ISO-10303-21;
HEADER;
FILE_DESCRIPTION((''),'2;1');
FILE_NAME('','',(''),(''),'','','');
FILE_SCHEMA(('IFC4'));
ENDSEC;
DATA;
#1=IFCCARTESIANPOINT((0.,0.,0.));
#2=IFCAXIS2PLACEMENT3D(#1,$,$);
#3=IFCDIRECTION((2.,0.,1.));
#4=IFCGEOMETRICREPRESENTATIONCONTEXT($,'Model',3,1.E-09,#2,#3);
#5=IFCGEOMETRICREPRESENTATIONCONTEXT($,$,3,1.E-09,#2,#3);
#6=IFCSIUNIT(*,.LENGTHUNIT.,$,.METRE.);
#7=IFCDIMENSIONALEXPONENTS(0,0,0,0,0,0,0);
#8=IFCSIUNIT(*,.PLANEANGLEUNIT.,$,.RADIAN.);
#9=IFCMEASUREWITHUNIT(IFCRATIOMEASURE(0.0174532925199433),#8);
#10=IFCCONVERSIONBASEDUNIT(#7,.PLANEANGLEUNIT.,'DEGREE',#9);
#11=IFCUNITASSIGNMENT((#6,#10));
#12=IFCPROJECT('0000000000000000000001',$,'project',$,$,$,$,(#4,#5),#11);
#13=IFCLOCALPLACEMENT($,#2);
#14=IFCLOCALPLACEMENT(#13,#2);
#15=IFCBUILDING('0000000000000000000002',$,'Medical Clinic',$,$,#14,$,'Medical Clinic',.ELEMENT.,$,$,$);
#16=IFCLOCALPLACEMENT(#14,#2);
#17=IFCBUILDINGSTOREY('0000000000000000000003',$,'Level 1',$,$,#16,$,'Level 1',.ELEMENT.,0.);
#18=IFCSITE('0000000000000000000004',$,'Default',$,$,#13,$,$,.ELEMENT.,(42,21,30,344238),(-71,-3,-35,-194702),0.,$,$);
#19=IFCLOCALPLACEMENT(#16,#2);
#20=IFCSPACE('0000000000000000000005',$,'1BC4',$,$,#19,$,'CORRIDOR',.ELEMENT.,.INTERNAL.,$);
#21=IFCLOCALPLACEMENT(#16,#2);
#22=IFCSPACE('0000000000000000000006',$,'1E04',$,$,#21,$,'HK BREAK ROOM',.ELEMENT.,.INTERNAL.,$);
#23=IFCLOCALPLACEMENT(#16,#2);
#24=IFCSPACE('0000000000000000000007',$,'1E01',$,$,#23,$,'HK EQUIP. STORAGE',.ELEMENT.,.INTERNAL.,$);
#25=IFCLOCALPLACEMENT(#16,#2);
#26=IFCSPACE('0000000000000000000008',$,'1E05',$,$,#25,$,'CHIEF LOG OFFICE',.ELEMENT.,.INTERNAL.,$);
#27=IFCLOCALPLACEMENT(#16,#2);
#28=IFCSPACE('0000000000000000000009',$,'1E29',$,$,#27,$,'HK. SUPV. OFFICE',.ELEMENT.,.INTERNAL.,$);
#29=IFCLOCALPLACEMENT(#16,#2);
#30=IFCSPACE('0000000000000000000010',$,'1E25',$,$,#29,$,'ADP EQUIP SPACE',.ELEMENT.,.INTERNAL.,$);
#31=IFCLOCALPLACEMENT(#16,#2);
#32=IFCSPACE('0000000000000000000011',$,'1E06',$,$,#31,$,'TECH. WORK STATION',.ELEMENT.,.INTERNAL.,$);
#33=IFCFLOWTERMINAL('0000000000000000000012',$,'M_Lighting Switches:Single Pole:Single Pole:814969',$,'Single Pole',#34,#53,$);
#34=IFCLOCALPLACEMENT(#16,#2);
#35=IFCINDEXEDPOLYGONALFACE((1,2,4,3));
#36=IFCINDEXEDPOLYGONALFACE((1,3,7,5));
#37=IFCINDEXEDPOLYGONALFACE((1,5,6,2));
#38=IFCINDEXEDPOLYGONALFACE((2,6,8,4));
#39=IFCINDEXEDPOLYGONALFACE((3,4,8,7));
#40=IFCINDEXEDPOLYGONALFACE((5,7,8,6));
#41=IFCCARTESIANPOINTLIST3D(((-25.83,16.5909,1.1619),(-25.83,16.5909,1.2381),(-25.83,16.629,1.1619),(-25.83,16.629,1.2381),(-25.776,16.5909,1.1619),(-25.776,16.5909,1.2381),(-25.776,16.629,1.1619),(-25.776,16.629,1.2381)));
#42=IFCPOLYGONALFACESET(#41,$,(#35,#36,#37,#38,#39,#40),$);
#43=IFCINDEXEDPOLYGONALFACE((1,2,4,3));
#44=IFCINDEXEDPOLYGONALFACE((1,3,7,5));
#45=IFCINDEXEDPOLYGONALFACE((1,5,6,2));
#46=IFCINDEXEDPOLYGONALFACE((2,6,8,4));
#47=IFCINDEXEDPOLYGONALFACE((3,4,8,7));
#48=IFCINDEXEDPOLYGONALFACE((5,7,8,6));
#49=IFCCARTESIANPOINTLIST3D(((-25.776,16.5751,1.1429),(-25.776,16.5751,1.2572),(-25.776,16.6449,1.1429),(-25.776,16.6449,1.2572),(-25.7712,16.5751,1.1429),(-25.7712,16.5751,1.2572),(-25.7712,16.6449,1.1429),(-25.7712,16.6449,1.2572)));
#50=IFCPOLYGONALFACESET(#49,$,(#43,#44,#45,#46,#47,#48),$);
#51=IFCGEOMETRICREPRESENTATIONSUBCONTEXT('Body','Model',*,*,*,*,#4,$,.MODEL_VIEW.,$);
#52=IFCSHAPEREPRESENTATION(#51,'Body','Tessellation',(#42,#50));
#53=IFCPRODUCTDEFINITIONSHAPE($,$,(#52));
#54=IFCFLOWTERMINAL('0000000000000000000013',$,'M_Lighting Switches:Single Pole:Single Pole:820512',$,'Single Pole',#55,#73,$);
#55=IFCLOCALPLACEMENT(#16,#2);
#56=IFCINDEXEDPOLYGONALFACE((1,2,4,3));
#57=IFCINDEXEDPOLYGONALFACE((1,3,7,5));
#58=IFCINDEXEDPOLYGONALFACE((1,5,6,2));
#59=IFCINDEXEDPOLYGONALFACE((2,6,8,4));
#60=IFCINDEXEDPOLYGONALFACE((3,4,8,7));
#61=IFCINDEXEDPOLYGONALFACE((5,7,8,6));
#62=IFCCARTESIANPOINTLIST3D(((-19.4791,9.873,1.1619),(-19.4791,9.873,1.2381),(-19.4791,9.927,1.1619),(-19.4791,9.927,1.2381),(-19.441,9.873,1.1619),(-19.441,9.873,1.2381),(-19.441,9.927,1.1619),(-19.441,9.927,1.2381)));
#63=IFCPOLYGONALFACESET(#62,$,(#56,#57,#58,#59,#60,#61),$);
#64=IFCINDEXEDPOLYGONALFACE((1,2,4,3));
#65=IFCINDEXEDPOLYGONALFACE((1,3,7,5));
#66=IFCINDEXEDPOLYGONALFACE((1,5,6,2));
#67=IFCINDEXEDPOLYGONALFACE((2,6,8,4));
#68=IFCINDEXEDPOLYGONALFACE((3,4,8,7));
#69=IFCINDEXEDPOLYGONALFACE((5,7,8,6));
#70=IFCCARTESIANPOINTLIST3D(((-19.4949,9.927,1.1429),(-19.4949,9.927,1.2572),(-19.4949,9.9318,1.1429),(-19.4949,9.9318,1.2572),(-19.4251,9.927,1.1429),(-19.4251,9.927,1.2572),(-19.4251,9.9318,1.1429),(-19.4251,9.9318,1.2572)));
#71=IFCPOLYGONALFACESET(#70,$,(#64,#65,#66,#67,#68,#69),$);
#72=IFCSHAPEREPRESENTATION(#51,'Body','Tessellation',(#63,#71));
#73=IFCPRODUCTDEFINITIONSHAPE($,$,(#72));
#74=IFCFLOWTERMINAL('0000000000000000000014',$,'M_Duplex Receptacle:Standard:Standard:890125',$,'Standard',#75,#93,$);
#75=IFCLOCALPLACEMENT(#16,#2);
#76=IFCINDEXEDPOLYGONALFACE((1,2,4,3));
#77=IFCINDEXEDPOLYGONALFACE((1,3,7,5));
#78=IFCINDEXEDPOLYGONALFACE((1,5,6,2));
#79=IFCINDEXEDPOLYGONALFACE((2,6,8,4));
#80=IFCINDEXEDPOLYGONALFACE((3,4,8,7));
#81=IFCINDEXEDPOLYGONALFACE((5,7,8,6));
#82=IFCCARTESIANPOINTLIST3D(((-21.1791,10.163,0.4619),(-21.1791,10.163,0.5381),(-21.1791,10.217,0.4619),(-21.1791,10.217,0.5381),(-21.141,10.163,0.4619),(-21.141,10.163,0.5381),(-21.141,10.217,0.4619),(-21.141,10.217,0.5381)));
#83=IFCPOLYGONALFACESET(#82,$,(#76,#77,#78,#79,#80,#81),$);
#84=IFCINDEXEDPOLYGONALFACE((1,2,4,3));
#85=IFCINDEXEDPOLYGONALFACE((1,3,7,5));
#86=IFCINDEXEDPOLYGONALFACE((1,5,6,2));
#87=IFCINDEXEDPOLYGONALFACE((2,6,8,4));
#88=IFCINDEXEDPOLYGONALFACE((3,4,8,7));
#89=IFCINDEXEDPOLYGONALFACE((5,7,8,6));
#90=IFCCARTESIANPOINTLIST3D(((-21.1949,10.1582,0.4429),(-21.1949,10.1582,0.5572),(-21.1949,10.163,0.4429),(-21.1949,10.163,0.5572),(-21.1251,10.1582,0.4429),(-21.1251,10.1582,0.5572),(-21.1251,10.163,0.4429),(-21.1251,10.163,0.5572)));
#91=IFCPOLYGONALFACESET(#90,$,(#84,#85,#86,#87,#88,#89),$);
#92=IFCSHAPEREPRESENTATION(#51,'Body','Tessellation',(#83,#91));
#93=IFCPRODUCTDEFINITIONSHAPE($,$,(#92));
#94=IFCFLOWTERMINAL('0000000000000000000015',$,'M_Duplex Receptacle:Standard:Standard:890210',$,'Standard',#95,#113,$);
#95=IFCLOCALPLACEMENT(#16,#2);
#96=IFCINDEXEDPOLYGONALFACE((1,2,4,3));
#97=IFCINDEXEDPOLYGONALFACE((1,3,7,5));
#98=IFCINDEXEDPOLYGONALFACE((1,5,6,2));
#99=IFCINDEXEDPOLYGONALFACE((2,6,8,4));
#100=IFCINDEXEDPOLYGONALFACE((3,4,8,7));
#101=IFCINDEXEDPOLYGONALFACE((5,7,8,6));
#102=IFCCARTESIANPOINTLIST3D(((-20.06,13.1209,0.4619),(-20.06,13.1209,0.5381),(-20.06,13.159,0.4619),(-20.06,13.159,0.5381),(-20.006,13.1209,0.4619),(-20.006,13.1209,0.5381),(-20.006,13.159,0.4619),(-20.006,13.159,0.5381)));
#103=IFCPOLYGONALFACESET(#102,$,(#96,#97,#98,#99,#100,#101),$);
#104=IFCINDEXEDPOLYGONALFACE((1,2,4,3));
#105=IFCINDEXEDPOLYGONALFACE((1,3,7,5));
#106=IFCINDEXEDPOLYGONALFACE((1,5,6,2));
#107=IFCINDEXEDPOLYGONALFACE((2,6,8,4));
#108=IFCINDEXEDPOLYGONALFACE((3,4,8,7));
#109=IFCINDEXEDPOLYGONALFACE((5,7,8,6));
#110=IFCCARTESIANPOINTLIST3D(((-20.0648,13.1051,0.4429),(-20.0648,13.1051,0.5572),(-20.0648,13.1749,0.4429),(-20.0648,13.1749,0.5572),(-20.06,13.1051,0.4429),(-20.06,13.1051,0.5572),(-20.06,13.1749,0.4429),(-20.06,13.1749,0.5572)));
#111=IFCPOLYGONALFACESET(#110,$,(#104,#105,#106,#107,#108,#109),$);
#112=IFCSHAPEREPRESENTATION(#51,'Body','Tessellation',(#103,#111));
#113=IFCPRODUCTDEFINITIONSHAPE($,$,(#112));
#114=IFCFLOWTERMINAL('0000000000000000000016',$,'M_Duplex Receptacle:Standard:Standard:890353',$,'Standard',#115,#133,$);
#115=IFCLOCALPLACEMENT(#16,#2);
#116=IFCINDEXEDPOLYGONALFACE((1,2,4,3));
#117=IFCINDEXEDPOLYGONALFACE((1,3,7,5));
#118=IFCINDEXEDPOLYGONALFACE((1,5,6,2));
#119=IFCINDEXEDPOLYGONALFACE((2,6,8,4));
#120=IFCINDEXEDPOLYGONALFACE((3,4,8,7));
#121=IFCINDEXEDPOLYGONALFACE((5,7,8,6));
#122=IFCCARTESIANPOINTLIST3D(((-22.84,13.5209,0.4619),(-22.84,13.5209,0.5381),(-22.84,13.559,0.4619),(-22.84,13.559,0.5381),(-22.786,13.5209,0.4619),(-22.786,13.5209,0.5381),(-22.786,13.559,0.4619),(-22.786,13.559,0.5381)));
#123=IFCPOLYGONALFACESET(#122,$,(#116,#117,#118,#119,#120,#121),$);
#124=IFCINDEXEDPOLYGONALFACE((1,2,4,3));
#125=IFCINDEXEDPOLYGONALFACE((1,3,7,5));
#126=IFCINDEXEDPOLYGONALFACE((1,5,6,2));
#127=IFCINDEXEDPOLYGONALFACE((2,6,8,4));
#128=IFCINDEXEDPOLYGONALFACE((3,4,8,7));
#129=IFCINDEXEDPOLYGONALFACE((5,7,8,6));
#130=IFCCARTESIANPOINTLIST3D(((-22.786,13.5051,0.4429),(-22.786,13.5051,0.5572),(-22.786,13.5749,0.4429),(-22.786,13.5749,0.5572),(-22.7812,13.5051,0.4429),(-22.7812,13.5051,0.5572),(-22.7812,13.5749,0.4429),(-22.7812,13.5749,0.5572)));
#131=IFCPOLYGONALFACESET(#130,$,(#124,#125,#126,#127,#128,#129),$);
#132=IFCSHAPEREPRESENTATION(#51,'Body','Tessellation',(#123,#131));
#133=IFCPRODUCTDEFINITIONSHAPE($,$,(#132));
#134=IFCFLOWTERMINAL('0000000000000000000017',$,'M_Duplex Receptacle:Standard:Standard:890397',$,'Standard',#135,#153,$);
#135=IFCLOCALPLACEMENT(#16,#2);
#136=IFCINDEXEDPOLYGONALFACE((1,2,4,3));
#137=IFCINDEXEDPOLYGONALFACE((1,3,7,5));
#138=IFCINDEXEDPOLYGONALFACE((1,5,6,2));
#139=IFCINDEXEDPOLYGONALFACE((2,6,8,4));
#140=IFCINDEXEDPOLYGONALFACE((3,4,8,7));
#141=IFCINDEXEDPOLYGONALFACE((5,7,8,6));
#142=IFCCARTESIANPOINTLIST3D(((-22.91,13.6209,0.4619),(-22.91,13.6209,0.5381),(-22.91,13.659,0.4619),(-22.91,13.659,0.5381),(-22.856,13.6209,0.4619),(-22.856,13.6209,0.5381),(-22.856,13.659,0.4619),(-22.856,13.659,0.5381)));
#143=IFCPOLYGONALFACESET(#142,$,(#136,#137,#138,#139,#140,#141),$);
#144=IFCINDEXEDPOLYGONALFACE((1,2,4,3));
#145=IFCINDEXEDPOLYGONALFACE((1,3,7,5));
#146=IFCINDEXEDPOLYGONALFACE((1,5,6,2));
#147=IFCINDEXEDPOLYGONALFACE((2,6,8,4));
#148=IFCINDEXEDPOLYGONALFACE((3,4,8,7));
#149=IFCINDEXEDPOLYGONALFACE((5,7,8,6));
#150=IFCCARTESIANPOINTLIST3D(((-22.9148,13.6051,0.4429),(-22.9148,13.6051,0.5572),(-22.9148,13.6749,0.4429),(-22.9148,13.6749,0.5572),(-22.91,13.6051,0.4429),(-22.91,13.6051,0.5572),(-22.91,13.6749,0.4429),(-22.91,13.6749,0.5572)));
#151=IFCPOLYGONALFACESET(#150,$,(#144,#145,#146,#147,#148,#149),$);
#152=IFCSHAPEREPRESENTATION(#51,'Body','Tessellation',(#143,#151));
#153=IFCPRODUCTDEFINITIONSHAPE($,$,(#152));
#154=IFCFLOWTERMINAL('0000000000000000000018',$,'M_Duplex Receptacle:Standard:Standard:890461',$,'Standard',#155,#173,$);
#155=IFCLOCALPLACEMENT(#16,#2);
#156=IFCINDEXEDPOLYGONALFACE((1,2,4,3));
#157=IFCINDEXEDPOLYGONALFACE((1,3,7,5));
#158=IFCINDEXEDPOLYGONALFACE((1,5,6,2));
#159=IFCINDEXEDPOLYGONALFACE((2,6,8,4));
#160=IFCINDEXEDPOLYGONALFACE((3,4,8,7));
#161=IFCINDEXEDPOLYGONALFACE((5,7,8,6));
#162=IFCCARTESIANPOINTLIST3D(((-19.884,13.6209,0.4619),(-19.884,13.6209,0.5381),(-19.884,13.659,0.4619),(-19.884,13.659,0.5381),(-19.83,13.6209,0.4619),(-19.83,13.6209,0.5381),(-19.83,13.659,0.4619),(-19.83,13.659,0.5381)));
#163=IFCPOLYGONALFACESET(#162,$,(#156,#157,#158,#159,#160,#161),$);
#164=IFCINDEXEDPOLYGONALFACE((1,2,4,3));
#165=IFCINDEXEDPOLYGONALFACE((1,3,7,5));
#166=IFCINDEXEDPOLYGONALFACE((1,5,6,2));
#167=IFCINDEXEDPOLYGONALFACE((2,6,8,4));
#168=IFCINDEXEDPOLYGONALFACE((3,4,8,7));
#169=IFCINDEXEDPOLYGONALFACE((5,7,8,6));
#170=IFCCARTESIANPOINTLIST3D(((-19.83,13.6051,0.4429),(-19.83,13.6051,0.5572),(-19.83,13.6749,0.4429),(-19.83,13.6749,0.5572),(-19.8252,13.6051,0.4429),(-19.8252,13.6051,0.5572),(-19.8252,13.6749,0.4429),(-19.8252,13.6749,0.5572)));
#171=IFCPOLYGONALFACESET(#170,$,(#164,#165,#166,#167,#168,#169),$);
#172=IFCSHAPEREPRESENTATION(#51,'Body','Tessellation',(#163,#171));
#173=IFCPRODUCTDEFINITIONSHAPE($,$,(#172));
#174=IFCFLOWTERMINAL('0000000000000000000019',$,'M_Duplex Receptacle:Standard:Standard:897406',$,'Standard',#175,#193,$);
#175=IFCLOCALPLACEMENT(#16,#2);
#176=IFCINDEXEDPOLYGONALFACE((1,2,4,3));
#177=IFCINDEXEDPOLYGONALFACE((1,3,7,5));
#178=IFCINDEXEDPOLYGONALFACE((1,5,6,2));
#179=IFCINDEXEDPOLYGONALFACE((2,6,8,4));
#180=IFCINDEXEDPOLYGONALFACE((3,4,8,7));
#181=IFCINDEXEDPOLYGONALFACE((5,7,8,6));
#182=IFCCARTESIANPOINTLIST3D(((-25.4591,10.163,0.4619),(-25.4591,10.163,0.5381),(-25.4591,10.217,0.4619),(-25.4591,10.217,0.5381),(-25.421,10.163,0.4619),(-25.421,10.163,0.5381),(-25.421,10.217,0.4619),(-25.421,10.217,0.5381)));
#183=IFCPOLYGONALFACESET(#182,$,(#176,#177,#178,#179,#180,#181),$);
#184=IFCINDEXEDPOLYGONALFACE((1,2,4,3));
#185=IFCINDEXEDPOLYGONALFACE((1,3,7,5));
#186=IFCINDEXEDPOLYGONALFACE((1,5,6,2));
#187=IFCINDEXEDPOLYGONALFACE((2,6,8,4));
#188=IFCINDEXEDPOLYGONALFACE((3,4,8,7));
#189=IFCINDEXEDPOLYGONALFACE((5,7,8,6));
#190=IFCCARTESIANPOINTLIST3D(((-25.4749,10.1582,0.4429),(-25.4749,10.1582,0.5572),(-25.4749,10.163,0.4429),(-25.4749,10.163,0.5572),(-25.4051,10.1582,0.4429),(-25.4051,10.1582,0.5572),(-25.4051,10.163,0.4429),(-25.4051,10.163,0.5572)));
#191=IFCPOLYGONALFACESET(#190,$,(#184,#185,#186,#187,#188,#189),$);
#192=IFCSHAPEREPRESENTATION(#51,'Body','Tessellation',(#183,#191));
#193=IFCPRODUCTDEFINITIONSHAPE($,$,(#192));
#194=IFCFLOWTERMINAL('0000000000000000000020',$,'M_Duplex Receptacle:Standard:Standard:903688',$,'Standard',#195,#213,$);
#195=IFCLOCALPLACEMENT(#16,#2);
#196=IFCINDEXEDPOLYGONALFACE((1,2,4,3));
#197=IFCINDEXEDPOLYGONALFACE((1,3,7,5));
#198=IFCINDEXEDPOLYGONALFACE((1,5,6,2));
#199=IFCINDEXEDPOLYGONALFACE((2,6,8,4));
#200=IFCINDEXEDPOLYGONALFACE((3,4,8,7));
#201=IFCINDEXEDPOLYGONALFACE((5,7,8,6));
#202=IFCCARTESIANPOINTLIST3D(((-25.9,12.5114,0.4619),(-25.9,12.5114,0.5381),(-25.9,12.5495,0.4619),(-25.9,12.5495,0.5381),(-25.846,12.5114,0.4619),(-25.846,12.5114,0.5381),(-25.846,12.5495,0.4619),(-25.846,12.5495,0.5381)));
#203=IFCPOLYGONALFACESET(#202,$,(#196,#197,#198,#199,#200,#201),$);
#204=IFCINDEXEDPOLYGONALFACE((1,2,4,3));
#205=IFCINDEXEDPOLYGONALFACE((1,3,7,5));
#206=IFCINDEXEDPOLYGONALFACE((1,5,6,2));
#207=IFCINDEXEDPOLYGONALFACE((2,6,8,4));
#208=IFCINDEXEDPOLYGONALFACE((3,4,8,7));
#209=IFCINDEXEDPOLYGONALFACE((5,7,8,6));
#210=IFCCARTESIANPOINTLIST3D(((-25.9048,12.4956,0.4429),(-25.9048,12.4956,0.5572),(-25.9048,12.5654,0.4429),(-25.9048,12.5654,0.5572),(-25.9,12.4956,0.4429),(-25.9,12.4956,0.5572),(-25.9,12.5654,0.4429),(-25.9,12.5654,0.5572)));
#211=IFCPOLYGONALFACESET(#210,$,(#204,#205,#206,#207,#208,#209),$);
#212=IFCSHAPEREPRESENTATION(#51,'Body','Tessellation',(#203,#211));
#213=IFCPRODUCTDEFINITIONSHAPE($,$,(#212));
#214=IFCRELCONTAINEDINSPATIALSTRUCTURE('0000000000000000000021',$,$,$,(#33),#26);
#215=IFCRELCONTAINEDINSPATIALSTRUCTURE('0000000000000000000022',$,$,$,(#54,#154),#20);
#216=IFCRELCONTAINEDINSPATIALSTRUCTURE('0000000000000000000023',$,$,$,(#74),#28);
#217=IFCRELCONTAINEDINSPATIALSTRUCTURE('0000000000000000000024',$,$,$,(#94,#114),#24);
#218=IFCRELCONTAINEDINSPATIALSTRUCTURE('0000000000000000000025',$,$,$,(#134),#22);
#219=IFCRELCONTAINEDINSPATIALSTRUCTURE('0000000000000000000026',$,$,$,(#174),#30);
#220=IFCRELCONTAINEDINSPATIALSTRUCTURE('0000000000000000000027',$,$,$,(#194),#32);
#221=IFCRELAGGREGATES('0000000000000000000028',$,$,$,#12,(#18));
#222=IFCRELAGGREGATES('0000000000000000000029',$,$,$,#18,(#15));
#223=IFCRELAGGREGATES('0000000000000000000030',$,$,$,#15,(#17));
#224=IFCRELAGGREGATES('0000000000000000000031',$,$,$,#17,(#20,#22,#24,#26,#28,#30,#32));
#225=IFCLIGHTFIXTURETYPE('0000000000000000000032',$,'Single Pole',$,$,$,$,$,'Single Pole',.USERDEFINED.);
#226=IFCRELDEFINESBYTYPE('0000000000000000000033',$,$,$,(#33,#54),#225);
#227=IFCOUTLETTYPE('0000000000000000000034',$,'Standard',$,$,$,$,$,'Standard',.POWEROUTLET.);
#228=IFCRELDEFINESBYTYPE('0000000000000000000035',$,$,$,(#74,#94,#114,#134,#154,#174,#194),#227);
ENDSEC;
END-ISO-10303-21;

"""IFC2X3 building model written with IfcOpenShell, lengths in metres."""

from ifc_helpers import new_model, entity, si_unit, converted_unit, direction, frame, frame_2d, origin, origin_2d_with_axis, place, context, subcontext, project, spatial, rectangle, extrude, source, transform, mapped, type_object, type_shapes, element, save


model = new_model("IFC2X3")

# Units and contexts
model_context = context("Model", 3, precision=1e-09, world=origin(), true_north=direction((2.0, 0.0, 1.0)))
context_of_model = context(None, 3, precision=1e-09, world=origin(), true_north=direction((2.0, 0.0, 1.0)))
body_context = subcontext(model_context, "Body", "Model", "MODEL_VIEW")
ifc_project = project(units=[si_unit("LENGTHUNIT", "METRE"), converted_unit("PLANEANGLEUNIT", "DEGREE", entity("IfcRatioMeasure", 0.0174532925199433), si_unit("PLANEANGLEUNIT", "RADIAN"), dimensions=[0, 0, 0, 0, 0, 0, 0])], contexts=[model_context, context_of_model])

# Site, building, storey
site_placement = place(None, origin())
site = spatial("IfcSite", under=ifc_project, at=site_placement, Name="Default", CompositionType="ELEMENT", RefLatitude=(42, 21, 30, 344238), RefLongitude=(-71, -3, -35, -194702), RefElevation=0.0)
building_placement = place(site_placement, origin())
building = spatial("IfcBuilding", under=site, at=building_placement, Name="Medical Clinic", LongName="Medical Clinic", CompositionType="ELEMENT")
storey_placement = place(building_placement, origin())
storey = spatial("IfcBuildingStorey", under=building, at=storey_placement, Name="Level 1", LongName="Level 1", CompositionType="ELEMENT", Elevation=0.0)

# Shared definitions
space_1_placement = place(storey_placement, origin())
space_1 = spatial("IfcSpace", under=storey, at=space_1_placement, Name="1BC4", LongName="CORRIDOR", CompositionType="ELEMENT", InteriorOrExteriorSpace="INTERNAL")

# Shared definitions
space_2_placement = place(storey_placement, origin())
space_2 = spatial("IfcSpace", under=storey, at=space_2_placement, Name="1E04", LongName="HK BREAK ROOM", CompositionType="ELEMENT", InteriorOrExteriorSpace="INTERNAL")

# Shared definitions
light_fixture_type_1 = type_object("IfcLightFixtureType", Name="Single Pole", ElementType="Single Pole", PredefinedType="USERDEFINED")
shared_shape_1 = source(origin(), body_context, "Body", "SweptSolid", [
    extrude(rectangle(XDim=0.0381, YDim=0.0762, at=origin_2d_with_axis()), frame((0.0, 0.0, -0.054), z_axis=(0.0, 0.0, 1.0), x_axis=(-1.0, 0.0, 0.0)), (0.0, 0.0, 1.0), 0.054),
    extrude(rectangle(XDim=0.0698, YDim=0.1143, at=frame_2d((0.0, 0.0), x_axis=(1.0, 0.0))), frame((0.0, 0.0, 0.0), z_axis=(0.0, 0.0, 1.0), x_axis=(-1.0, 0.0, 0.0)), (0.0, 0.0, 1.0), 0.0048),
])
type_shapes(light_fixture_type_1, [shared_shape_1])

# Shared definitions
space_3_placement = place(storey_placement, origin())
space_3 = spatial("IfcSpace", under=storey, at=space_3_placement, Name="1E01", LongName="HK EQUIP. STORAGE", CompositionType="ELEMENT", InteriorOrExteriorSpace="INTERNAL")

# Shared definitions
space_4_placement = place(storey_placement, origin())
space_4 = spatial("IfcSpace", under=storey, at=space_4_placement, Name="1E05", LongName="CHIEF LOG OFFICE", CompositionType="ELEMENT", InteriorOrExteriorSpace="INTERNAL")

# Flow terminals
flow_terminal_1_placement = place(space_4_placement, frame((-25.776, 16.61, 1.2), z_axis=(1.0, 0.0, 0.0), x_axis=(0.0, 1.0, 0.0)))
element("IfcFlowTerminal", 1, at=flow_terminal_1_placement, inside=space_4, type_object=light_fixture_type_1, Name="M_Lighting Switches:Single Pole:Single Pole:814969", ObjectType="Single Pole", context=body_context, shape_type="MappedRepresentation", body=[
    mapped(shared_shape_1, transform((0.0, 0.0, 0.0), scale=1.0)),
])
flow_terminal_2_placement = place(space_1_placement, frame((-19.46, 9.927, 1.2), z_axis=(0.0, 1.0, 0.0), x_axis=(-1.0, 0.0, 0.0)))
element("IfcFlowTerminal", 2, at=flow_terminal_2_placement, inside=space_1, type_object=light_fixture_type_1, Name="M_Lighting Switches:Single Pole:Single Pole:820512", ObjectType="Single Pole", context=body_context, shape_type="MappedRepresentation", body=[
    mapped(shared_shape_1, transform((0.0, 0.0, 0.0), scale=1.0)),
])

# Shared definitions
space_5_placement = place(storey_placement, origin())
space_5 = spatial("IfcSpace", under=storey, at=space_5_placement, Name="1E29", LongName="HK. SUPV. OFFICE", CompositionType="ELEMENT", InteriorOrExteriorSpace="INTERNAL")

# Flow terminals
outlet_type = type_object("IfcOutletType", Name="Standard", ElementType="Standard", PredefinedType="POWEROUTLET")
shared_shape_2 = source(origin(), body_context, "Body", "SweptSolid", [
    extrude(rectangle(XDim=0.0381, YDim=0.0762, at=origin_2d_with_axis()), frame((0.0, 0.0, -0.054), z_axis=(0.0, 0.0, 1.0), x_axis=(-1.0, 0.0, 0.0)), (0.0, 0.0, 1.0), 0.054),
    extrude(rectangle(XDim=0.0698, YDim=0.1143, at=frame_2d((0.0, 0.0), x_axis=(1.0, 0.0))), frame((0.0, 0.0, 0.0), z_axis=(0.0, 0.0, 1.0), x_axis=(-1.0, 0.0, 0.0)), (0.0, 0.0, 1.0), 0.0048),
])
type_shapes(outlet_type, [shared_shape_2])
flow_terminal_3_placement = place(space_5_placement, frame((-21.16, 10.163, 0.5), z_axis=(0.0, -1.0, 0.0), x_axis=(1.0, 0.0, 0.0)))
element("IfcFlowTerminal", 3, at=flow_terminal_3_placement, inside=space_5, type_object=outlet_type, Name="M_Duplex Receptacle:Standard:Standard:890125", ObjectType="Standard", context=body_context, shape_type="MappedRepresentation", body=[
    mapped(shared_shape_2, transform((0.0, 0.0, 0.0), scale=1.0)),
])
for number, where, z_axis, x_axis, name in (
    (4, (-20.06, 13.14, 0.5), (-1.0, 0.0, 0.0), (0.0, -1.0, 0.0), "M_Duplex Receptacle:Standard:Standard:890210"),
    (5, (-22.786, 13.54, 0.5), (1.0, 0.0, 0.0), (0.0, 1.0, 0.0), "M_Duplex Receptacle:Standard:Standard:890353"),
):
    element("IfcFlowTerminal", number, at=place(space_3_placement, frame(where, z_axis=z_axis, x_axis=x_axis)), inside=space_3, type_object=outlet_type, Name=name, ObjectType="Standard", context=body_context, shape_type="MappedRepresentation", body=[
        mapped(shared_shape_2, transform((0.0, 0.0, 0.0), scale=1.0)),
    ])
flow_terminal_4_placement = place(space_2_placement, frame((-22.91, 13.64, 0.5), z_axis=(-1.0, 0.0, 0.0), x_axis=(0.0, -1.0, 0.0)))
element("IfcFlowTerminal", 6, at=flow_terminal_4_placement, inside=space_2, type_object=outlet_type, Name="M_Duplex Receptacle:Standard:Standard:890397", ObjectType="Standard", context=body_context, shape_type="MappedRepresentation", body=[
    mapped(shared_shape_2, transform((0.0, 0.0, 0.0), scale=1.0)),
])
flow_terminal_5_placement = place(space_1_placement, frame((-19.83, 13.64, 0.5), z_axis=(1.0, 0.0, 0.0), x_axis=(0.0, 1.0, 0.0)))
element("IfcFlowTerminal", 7, at=flow_terminal_5_placement, inside=space_1, type_object=outlet_type, Name="M_Duplex Receptacle:Standard:Standard:890461", ObjectType="Standard", context=body_context, shape_type="MappedRepresentation", body=[
    mapped(shared_shape_2, transform((0.0, 0.0, 0.0), scale=1.0)),
])

# Shared definitions
space_6_placement = place(storey_placement, origin())
space_6 = spatial("IfcSpace", under=storey, at=space_6_placement, Name="1E25", LongName="ADP EQUIP SPACE", CompositionType="ELEMENT", InteriorOrExteriorSpace="INTERNAL")

# Flow terminal
flow_terminal_6_placement = place(space_6_placement, frame((-25.44, 10.163, 0.5), z_axis=(0.0, -1.0, 0.0), x_axis=(1.0, 0.0, 0.0)))
element("IfcFlowTerminal", 8, at=flow_terminal_6_placement, inside=space_6, type_object=outlet_type, Name="M_Duplex Receptacle:Standard:Standard:897406", ObjectType="Standard", context=body_context, shape_type="MappedRepresentation", body=[
    mapped(shared_shape_2, transform((0.0, 0.0, 0.0), scale=1.0)),
])

# Shared definitions
space_7_placement = place(storey_placement, origin())
space_7 = spatial("IfcSpace", under=storey, at=space_7_placement, Name="1E06", LongName="TECH. WORK STATION", CompositionType="ELEMENT", InteriorOrExteriorSpace="INTERNAL")

# Flow terminal
flow_terminal_7_placement = place(space_7_placement, frame((-25.9, 12.5305, 0.5), z_axis=(-1.0, 0.0, 0.0), x_axis=(0.0, -1.0, 0.0)))
element("IfcFlowTerminal", 9, at=flow_terminal_7_placement, inside=space_7, type_object=outlet_type, Name="M_Duplex Receptacle:Standard:Standard:903688", ObjectType="Standard", context=body_context, shape_type="MappedRepresentation", body=[
    mapped(shared_shape_2, transform((0.0, 0.0, 0.0), scale=1.0)),
])

save(model, "model.ifc")
